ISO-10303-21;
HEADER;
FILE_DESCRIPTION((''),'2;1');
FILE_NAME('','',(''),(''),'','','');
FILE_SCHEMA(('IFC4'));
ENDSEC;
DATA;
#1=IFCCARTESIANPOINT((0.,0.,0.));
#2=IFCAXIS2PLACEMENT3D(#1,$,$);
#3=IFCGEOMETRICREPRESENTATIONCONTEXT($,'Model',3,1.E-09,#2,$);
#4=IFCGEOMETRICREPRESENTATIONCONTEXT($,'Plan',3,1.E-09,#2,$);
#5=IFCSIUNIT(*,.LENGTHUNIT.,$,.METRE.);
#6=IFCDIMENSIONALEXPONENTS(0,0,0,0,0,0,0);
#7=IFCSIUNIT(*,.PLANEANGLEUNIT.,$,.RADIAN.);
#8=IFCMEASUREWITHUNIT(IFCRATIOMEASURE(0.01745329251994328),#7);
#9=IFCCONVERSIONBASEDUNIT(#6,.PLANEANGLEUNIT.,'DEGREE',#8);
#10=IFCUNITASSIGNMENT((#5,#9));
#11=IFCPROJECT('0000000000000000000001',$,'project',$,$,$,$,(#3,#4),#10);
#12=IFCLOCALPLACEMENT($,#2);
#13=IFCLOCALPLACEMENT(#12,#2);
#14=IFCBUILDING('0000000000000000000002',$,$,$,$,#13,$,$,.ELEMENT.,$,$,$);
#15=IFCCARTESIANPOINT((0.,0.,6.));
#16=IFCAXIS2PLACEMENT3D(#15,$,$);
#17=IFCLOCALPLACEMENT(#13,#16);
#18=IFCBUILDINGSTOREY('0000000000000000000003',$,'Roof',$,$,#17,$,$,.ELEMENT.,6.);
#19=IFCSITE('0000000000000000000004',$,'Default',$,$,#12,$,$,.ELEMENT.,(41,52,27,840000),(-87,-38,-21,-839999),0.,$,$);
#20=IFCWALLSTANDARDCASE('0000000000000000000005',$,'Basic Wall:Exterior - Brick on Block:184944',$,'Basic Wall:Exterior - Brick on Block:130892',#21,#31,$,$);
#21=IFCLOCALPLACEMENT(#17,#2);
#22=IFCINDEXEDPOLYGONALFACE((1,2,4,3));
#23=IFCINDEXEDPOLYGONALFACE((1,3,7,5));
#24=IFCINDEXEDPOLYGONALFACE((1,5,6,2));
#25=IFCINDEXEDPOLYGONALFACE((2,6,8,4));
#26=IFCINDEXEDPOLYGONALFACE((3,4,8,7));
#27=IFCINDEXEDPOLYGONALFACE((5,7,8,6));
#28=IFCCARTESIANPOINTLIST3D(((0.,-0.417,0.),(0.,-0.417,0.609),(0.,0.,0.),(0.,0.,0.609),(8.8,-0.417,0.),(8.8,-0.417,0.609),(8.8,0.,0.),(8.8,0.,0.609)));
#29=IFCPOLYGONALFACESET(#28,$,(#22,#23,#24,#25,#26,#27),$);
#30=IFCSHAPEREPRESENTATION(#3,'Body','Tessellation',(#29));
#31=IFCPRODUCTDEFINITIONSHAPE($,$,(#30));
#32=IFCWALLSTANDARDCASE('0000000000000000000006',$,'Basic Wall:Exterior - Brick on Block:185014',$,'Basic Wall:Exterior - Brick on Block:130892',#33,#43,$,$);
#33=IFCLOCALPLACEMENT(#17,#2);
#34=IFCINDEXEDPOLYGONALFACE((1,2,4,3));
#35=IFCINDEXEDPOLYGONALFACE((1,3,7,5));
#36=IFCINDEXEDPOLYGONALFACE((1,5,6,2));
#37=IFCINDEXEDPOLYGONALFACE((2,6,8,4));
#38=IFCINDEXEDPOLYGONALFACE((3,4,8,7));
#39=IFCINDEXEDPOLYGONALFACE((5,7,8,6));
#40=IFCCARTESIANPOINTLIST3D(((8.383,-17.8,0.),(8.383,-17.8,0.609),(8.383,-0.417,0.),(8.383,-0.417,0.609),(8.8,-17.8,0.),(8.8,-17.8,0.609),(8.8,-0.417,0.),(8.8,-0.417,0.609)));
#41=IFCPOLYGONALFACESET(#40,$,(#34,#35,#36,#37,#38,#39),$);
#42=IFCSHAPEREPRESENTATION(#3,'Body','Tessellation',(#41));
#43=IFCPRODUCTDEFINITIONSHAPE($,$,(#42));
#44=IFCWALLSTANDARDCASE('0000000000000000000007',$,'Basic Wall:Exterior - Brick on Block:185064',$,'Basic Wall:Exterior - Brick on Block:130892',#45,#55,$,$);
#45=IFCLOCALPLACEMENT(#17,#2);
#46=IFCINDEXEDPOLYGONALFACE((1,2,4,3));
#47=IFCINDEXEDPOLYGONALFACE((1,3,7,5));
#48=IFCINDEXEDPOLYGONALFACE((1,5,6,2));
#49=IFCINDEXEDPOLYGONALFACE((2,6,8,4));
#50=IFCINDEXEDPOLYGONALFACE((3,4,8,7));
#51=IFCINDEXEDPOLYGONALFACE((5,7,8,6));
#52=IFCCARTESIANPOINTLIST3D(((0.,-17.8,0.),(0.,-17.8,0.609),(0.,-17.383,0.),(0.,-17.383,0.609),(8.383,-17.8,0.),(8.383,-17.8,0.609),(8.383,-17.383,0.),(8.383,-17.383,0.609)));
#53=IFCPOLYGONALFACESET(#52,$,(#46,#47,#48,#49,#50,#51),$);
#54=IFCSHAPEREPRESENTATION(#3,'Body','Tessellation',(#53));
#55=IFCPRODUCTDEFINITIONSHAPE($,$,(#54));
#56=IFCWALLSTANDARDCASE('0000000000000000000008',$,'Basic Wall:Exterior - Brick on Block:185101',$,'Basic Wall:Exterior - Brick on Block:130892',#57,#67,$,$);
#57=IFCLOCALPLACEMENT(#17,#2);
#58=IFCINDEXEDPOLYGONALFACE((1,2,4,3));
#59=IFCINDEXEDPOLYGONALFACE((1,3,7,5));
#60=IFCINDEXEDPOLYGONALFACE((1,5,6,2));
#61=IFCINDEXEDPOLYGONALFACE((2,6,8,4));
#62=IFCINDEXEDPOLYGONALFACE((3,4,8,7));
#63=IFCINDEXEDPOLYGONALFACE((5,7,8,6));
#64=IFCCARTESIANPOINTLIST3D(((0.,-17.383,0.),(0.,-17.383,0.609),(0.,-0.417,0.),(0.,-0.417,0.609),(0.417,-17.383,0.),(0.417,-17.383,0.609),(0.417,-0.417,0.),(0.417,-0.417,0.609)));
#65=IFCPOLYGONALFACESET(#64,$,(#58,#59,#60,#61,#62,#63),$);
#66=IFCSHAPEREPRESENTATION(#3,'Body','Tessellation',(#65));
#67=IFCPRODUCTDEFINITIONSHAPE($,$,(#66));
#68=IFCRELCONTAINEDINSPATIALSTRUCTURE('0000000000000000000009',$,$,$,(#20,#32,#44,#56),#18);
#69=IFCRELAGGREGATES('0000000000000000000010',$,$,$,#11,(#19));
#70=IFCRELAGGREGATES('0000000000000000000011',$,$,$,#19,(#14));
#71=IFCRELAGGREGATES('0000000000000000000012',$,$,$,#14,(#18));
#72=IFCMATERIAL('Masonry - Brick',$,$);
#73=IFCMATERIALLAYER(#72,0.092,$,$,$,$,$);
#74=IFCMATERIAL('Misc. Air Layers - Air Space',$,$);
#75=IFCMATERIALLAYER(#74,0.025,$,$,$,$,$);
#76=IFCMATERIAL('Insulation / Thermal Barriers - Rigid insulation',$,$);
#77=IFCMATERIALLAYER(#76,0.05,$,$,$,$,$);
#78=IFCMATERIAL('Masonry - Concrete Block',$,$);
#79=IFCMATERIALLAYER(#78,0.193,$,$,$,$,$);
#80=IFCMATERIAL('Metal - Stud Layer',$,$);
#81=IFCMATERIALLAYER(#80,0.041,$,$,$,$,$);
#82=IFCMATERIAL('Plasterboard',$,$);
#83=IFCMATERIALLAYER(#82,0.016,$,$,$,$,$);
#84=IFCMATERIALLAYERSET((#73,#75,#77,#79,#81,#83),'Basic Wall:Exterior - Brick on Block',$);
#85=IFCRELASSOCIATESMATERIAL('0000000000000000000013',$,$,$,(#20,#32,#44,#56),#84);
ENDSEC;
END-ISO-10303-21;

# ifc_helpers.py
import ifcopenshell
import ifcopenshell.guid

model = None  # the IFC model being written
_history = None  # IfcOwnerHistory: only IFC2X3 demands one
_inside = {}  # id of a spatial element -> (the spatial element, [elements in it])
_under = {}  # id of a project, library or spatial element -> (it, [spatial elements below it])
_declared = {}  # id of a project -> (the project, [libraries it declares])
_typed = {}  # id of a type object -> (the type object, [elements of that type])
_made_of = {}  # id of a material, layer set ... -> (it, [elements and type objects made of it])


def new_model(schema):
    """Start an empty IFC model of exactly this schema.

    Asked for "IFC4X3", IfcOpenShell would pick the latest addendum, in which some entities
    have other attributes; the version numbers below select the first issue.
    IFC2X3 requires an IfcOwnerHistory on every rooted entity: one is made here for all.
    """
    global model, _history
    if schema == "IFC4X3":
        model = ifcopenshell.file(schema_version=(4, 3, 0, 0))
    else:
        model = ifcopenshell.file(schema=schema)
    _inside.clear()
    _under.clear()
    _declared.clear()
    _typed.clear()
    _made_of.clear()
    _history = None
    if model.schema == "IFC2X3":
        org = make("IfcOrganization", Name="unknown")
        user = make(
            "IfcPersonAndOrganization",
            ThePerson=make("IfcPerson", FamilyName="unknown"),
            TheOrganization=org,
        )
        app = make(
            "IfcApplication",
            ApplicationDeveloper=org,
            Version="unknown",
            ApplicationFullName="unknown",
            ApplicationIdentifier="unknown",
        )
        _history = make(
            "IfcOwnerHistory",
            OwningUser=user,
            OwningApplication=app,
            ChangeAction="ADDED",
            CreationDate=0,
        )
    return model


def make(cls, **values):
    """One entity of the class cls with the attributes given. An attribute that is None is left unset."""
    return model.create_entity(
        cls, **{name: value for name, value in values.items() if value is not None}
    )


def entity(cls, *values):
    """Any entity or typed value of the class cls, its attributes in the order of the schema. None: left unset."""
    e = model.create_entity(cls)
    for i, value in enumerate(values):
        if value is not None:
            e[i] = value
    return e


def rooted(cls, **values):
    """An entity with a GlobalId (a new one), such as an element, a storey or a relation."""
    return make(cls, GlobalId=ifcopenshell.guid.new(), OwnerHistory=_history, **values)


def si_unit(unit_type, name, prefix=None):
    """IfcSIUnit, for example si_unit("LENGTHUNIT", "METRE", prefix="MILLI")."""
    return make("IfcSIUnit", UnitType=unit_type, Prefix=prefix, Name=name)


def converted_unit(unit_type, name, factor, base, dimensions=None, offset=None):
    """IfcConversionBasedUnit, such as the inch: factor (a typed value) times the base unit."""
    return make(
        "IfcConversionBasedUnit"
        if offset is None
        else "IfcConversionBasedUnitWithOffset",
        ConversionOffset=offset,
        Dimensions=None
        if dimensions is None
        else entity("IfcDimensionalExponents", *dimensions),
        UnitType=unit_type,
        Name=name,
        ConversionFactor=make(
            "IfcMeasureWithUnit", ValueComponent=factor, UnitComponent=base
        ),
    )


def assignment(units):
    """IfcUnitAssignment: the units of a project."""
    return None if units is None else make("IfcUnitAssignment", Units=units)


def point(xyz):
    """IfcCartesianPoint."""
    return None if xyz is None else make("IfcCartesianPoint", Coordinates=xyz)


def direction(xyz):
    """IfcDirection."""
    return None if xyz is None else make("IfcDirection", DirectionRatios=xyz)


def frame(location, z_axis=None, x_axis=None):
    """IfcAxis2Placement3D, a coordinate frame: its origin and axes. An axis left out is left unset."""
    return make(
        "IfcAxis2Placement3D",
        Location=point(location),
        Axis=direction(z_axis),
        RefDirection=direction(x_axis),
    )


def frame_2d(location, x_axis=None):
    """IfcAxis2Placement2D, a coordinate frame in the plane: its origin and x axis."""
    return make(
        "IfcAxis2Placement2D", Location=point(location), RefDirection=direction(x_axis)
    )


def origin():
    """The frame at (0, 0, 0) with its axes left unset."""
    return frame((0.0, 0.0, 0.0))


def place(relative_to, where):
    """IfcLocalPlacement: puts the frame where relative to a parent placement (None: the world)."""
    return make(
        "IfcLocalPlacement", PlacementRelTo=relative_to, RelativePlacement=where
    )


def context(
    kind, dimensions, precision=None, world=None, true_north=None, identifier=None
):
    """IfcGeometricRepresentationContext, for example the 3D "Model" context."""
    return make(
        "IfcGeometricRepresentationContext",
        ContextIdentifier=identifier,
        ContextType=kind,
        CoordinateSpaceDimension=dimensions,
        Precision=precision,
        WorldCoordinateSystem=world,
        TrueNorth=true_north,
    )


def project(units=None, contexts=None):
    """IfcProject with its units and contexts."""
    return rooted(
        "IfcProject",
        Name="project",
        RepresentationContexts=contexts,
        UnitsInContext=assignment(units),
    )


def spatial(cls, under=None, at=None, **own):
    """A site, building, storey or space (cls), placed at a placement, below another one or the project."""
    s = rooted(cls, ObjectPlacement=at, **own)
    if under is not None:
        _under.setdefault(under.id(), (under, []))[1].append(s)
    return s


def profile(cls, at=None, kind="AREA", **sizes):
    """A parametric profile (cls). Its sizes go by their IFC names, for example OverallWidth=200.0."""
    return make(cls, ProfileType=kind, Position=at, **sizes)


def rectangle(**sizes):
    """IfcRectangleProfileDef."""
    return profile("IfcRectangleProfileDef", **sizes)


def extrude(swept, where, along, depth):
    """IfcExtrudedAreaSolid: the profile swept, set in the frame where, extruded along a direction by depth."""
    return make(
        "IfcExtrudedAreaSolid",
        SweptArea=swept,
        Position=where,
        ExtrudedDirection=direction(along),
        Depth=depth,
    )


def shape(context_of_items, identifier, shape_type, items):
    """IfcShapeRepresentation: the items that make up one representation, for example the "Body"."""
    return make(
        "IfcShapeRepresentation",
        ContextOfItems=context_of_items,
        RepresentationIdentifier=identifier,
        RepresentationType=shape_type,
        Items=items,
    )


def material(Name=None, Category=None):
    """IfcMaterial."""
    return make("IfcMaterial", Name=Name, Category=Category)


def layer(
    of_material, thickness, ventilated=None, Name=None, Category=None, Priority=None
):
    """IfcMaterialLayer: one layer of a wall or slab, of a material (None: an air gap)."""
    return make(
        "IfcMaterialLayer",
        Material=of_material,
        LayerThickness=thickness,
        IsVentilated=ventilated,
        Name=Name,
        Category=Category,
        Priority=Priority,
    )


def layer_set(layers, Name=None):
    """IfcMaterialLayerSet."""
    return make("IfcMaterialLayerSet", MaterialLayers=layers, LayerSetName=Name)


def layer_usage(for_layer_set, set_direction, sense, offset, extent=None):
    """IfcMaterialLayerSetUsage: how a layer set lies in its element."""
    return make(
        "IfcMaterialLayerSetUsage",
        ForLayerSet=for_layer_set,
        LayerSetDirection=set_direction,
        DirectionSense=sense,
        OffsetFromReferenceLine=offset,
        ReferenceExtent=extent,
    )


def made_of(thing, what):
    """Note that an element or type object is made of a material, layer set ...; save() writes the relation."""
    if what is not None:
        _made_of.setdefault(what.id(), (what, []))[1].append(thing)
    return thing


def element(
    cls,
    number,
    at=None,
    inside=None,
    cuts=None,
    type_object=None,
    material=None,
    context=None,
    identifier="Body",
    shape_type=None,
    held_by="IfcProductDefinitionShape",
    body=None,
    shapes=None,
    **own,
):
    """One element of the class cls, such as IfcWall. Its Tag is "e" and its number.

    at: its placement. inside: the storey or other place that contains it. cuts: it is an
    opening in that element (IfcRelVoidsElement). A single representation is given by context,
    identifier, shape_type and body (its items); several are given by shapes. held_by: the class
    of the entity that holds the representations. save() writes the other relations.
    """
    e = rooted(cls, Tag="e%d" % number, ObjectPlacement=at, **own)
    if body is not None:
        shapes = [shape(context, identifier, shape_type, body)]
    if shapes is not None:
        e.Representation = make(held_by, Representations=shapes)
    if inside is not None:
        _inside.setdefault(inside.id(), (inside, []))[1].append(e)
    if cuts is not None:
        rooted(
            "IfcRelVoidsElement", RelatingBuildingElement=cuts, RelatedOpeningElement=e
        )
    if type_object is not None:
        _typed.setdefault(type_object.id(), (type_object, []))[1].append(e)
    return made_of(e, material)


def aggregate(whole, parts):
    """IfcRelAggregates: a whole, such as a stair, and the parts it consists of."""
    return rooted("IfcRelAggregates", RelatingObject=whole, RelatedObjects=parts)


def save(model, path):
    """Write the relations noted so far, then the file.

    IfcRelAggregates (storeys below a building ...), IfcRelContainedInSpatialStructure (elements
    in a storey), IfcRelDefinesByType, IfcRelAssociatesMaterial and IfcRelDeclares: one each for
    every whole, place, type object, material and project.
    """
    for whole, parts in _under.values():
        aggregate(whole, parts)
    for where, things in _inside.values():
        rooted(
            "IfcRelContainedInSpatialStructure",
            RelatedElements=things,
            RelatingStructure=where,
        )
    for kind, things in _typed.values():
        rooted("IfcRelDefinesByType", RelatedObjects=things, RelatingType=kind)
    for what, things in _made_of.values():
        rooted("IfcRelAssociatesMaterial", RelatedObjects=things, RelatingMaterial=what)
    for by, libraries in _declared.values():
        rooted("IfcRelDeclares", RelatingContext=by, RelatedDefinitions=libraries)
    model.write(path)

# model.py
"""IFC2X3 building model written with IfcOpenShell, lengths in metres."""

from ifc_helpers import new_model, entity, si_unit, converted_unit, frame, frame_2d, origin, place, context, project, spatial, rectangle, extrude, material, layer, layer_set, layer_usage, element, save


model = new_model("IFC2X3")

# Units and contexts
model_context = context("Model", 3, precision=1e-09, world=origin())
plan_context = context("Plan", 3, precision=1e-09, world=origin())
ifc_project = project(units=[si_unit("LENGTHUNIT", "METRE"), converted_unit("PLANEANGLEUNIT", "DEGREE", entity("IfcRatioMeasure", 0.01745329251994328), si_unit("PLANEANGLEUNIT", "RADIAN"), dimensions=[0, 0, 0, 0, 0, 0, 0])], contexts=[model_context, plan_context])

# Site, building, storey
site_placement = place(None, origin())
site = spatial("IfcSite", under=ifc_project, at=site_placement, Name="Default", CompositionType="ELEMENT", RefLatitude=(41, 52, 27, 840000), RefLongitude=(-87, -38, -21, -839999), RefElevation=0.0)
building_placement = place(site_placement, origin())
building = spatial("IfcBuilding", under=site, at=building_placement, CompositionType="ELEMENT")
storey_placement = place(building_placement, frame((0.0, 0.0, 6.0)))
storey = spatial("IfcBuildingStorey", under=building, at=storey_placement, Name="Roof", CompositionType="ELEMENT", Elevation=6.0)

# Walls
ifc_material_1 = material(Name="Masonry - Brick")
ifc_layer_1 = layer(ifc_material_1, 0.092)
ifc_material_2 = material(Name="Misc. Air Layers - Air Space")
ifc_layer_2 = layer(ifc_material_2, 0.025)
ifc_material_3 = material(Name="Insulation / Thermal Barriers - Rigid insulation")
ifc_layer_3 = layer(ifc_material_3, 0.05)
ifc_material_4 = material(Name="Masonry - Concrete Block")
ifc_layer_4 = layer(ifc_material_4, 0.193)
ifc_material_5 = material(Name="Metal - Stud Layer")
ifc_layer_5 = layer(ifc_material_5, 0.041)
ifc_material_6 = material(Name="Plasterboard")
ifc_layer_6 = layer(ifc_material_6, 0.016)
ifc_layer_set = layer_set([ifc_layer_1, ifc_layer_2, ifc_layer_3, ifc_layer_4, ifc_layer_5, ifc_layer_6], Name="Basic Wall:Exterior - Brick on Block")
ifc_layer_usage_1 = layer_usage(ifc_layer_set, "AXIS2", "NEGATIVE", 0.2085)
wall_1_placement = place(storey_placement, frame((0.0, -0.2085, 0.0)))
element("IfcWallStandardCase", 1, at=wall_1_placement, inside=storey, material=ifc_layer_usage_1, Name="Basic Wall:Exterior - Brick on Block:184944", ObjectType="Basic Wall:Exterior - Brick on Block:130892", context=model_context, shape_type="SweptSolid", body=[
    extrude(rectangle(XDim=8.8, YDim=0.417, at=frame_2d((4.4, 0.0), x_axis=(-1.0, 0.0))), origin(), (0.0, 0.0, 1.0), 0.609),
])
ifc_layer_usage_2 = layer_usage(ifc_layer_set, "AXIS2", "NEGATIVE", 0.2085)
wall_2_placement = place(storey_placement, frame((8.5915, -0.417, 0.0), z_axis=(0.0, 0.0, 1.0), x_axis=(0.0, -1.0, 0.0)))
element("IfcWallStandardCase", 2, at=wall_2_placement, inside=storey, material=ifc_layer_usage_2, Name="Basic Wall:Exterior - Brick on Block:185014", ObjectType="Basic Wall:Exterior - Brick on Block:130892", context=model_context, shape_type="SweptSolid", body=[
    extrude(rectangle(XDim=17.383, YDim=0.417, at=frame_2d((8.6915, 0.0), x_axis=(-1.0, 0.0))), origin(), (0.0, 0.0, 1.0), 0.609),
])
ifc_layer_usage_3 = layer_usage(ifc_layer_set, "AXIS2", "NEGATIVE", 0.2085)
wall_3_placement = place(storey_placement, frame((8.383, -17.5915, 0.0), z_axis=(0.0, 0.0, 1.0), x_axis=(-1.0, 0.0, 0.0)))
element("IfcWallStandardCase", 3, at=wall_3_placement, inside=storey, material=ifc_layer_usage_3, Name="Basic Wall:Exterior - Brick on Block:185064", ObjectType="Basic Wall:Exterior - Brick on Block:130892", context=model_context, shape_type="SweptSolid", body=[
    extrude(rectangle(XDim=8.383, YDim=0.417, at=frame_2d((4.1915, 0.0), x_axis=(-1.0, 0.0))), origin(), (0.0, 0.0, 1.0), 0.609),
])
ifc_layer_usage_4 = layer_usage(ifc_layer_set, "AXIS2", "NEGATIVE", 0.2085)
wall_4_placement = place(storey_placement, frame((0.2085, -17.383, 0.0), z_axis=(0.0, 0.0, 1.0), x_axis=(0.0, 1.0, 0.0)))
element("IfcWallStandardCase", 4, at=wall_4_placement, inside=storey, material=ifc_layer_usage_4, Name="Basic Wall:Exterior - Brick on Block:185101", ObjectType="Basic Wall:Exterior - Brick on Block:130892", context=model_context, shape_type="SweptSolid", body=[
    extrude(rectangle(XDim=16.966, YDim=0.417, at=frame_2d((8.483, 0.0), x_axis=(-1.0, 0.0))), origin(), (0.0, 0.0, 1.0), 0.609),
])

save(model, "model.ifc")
